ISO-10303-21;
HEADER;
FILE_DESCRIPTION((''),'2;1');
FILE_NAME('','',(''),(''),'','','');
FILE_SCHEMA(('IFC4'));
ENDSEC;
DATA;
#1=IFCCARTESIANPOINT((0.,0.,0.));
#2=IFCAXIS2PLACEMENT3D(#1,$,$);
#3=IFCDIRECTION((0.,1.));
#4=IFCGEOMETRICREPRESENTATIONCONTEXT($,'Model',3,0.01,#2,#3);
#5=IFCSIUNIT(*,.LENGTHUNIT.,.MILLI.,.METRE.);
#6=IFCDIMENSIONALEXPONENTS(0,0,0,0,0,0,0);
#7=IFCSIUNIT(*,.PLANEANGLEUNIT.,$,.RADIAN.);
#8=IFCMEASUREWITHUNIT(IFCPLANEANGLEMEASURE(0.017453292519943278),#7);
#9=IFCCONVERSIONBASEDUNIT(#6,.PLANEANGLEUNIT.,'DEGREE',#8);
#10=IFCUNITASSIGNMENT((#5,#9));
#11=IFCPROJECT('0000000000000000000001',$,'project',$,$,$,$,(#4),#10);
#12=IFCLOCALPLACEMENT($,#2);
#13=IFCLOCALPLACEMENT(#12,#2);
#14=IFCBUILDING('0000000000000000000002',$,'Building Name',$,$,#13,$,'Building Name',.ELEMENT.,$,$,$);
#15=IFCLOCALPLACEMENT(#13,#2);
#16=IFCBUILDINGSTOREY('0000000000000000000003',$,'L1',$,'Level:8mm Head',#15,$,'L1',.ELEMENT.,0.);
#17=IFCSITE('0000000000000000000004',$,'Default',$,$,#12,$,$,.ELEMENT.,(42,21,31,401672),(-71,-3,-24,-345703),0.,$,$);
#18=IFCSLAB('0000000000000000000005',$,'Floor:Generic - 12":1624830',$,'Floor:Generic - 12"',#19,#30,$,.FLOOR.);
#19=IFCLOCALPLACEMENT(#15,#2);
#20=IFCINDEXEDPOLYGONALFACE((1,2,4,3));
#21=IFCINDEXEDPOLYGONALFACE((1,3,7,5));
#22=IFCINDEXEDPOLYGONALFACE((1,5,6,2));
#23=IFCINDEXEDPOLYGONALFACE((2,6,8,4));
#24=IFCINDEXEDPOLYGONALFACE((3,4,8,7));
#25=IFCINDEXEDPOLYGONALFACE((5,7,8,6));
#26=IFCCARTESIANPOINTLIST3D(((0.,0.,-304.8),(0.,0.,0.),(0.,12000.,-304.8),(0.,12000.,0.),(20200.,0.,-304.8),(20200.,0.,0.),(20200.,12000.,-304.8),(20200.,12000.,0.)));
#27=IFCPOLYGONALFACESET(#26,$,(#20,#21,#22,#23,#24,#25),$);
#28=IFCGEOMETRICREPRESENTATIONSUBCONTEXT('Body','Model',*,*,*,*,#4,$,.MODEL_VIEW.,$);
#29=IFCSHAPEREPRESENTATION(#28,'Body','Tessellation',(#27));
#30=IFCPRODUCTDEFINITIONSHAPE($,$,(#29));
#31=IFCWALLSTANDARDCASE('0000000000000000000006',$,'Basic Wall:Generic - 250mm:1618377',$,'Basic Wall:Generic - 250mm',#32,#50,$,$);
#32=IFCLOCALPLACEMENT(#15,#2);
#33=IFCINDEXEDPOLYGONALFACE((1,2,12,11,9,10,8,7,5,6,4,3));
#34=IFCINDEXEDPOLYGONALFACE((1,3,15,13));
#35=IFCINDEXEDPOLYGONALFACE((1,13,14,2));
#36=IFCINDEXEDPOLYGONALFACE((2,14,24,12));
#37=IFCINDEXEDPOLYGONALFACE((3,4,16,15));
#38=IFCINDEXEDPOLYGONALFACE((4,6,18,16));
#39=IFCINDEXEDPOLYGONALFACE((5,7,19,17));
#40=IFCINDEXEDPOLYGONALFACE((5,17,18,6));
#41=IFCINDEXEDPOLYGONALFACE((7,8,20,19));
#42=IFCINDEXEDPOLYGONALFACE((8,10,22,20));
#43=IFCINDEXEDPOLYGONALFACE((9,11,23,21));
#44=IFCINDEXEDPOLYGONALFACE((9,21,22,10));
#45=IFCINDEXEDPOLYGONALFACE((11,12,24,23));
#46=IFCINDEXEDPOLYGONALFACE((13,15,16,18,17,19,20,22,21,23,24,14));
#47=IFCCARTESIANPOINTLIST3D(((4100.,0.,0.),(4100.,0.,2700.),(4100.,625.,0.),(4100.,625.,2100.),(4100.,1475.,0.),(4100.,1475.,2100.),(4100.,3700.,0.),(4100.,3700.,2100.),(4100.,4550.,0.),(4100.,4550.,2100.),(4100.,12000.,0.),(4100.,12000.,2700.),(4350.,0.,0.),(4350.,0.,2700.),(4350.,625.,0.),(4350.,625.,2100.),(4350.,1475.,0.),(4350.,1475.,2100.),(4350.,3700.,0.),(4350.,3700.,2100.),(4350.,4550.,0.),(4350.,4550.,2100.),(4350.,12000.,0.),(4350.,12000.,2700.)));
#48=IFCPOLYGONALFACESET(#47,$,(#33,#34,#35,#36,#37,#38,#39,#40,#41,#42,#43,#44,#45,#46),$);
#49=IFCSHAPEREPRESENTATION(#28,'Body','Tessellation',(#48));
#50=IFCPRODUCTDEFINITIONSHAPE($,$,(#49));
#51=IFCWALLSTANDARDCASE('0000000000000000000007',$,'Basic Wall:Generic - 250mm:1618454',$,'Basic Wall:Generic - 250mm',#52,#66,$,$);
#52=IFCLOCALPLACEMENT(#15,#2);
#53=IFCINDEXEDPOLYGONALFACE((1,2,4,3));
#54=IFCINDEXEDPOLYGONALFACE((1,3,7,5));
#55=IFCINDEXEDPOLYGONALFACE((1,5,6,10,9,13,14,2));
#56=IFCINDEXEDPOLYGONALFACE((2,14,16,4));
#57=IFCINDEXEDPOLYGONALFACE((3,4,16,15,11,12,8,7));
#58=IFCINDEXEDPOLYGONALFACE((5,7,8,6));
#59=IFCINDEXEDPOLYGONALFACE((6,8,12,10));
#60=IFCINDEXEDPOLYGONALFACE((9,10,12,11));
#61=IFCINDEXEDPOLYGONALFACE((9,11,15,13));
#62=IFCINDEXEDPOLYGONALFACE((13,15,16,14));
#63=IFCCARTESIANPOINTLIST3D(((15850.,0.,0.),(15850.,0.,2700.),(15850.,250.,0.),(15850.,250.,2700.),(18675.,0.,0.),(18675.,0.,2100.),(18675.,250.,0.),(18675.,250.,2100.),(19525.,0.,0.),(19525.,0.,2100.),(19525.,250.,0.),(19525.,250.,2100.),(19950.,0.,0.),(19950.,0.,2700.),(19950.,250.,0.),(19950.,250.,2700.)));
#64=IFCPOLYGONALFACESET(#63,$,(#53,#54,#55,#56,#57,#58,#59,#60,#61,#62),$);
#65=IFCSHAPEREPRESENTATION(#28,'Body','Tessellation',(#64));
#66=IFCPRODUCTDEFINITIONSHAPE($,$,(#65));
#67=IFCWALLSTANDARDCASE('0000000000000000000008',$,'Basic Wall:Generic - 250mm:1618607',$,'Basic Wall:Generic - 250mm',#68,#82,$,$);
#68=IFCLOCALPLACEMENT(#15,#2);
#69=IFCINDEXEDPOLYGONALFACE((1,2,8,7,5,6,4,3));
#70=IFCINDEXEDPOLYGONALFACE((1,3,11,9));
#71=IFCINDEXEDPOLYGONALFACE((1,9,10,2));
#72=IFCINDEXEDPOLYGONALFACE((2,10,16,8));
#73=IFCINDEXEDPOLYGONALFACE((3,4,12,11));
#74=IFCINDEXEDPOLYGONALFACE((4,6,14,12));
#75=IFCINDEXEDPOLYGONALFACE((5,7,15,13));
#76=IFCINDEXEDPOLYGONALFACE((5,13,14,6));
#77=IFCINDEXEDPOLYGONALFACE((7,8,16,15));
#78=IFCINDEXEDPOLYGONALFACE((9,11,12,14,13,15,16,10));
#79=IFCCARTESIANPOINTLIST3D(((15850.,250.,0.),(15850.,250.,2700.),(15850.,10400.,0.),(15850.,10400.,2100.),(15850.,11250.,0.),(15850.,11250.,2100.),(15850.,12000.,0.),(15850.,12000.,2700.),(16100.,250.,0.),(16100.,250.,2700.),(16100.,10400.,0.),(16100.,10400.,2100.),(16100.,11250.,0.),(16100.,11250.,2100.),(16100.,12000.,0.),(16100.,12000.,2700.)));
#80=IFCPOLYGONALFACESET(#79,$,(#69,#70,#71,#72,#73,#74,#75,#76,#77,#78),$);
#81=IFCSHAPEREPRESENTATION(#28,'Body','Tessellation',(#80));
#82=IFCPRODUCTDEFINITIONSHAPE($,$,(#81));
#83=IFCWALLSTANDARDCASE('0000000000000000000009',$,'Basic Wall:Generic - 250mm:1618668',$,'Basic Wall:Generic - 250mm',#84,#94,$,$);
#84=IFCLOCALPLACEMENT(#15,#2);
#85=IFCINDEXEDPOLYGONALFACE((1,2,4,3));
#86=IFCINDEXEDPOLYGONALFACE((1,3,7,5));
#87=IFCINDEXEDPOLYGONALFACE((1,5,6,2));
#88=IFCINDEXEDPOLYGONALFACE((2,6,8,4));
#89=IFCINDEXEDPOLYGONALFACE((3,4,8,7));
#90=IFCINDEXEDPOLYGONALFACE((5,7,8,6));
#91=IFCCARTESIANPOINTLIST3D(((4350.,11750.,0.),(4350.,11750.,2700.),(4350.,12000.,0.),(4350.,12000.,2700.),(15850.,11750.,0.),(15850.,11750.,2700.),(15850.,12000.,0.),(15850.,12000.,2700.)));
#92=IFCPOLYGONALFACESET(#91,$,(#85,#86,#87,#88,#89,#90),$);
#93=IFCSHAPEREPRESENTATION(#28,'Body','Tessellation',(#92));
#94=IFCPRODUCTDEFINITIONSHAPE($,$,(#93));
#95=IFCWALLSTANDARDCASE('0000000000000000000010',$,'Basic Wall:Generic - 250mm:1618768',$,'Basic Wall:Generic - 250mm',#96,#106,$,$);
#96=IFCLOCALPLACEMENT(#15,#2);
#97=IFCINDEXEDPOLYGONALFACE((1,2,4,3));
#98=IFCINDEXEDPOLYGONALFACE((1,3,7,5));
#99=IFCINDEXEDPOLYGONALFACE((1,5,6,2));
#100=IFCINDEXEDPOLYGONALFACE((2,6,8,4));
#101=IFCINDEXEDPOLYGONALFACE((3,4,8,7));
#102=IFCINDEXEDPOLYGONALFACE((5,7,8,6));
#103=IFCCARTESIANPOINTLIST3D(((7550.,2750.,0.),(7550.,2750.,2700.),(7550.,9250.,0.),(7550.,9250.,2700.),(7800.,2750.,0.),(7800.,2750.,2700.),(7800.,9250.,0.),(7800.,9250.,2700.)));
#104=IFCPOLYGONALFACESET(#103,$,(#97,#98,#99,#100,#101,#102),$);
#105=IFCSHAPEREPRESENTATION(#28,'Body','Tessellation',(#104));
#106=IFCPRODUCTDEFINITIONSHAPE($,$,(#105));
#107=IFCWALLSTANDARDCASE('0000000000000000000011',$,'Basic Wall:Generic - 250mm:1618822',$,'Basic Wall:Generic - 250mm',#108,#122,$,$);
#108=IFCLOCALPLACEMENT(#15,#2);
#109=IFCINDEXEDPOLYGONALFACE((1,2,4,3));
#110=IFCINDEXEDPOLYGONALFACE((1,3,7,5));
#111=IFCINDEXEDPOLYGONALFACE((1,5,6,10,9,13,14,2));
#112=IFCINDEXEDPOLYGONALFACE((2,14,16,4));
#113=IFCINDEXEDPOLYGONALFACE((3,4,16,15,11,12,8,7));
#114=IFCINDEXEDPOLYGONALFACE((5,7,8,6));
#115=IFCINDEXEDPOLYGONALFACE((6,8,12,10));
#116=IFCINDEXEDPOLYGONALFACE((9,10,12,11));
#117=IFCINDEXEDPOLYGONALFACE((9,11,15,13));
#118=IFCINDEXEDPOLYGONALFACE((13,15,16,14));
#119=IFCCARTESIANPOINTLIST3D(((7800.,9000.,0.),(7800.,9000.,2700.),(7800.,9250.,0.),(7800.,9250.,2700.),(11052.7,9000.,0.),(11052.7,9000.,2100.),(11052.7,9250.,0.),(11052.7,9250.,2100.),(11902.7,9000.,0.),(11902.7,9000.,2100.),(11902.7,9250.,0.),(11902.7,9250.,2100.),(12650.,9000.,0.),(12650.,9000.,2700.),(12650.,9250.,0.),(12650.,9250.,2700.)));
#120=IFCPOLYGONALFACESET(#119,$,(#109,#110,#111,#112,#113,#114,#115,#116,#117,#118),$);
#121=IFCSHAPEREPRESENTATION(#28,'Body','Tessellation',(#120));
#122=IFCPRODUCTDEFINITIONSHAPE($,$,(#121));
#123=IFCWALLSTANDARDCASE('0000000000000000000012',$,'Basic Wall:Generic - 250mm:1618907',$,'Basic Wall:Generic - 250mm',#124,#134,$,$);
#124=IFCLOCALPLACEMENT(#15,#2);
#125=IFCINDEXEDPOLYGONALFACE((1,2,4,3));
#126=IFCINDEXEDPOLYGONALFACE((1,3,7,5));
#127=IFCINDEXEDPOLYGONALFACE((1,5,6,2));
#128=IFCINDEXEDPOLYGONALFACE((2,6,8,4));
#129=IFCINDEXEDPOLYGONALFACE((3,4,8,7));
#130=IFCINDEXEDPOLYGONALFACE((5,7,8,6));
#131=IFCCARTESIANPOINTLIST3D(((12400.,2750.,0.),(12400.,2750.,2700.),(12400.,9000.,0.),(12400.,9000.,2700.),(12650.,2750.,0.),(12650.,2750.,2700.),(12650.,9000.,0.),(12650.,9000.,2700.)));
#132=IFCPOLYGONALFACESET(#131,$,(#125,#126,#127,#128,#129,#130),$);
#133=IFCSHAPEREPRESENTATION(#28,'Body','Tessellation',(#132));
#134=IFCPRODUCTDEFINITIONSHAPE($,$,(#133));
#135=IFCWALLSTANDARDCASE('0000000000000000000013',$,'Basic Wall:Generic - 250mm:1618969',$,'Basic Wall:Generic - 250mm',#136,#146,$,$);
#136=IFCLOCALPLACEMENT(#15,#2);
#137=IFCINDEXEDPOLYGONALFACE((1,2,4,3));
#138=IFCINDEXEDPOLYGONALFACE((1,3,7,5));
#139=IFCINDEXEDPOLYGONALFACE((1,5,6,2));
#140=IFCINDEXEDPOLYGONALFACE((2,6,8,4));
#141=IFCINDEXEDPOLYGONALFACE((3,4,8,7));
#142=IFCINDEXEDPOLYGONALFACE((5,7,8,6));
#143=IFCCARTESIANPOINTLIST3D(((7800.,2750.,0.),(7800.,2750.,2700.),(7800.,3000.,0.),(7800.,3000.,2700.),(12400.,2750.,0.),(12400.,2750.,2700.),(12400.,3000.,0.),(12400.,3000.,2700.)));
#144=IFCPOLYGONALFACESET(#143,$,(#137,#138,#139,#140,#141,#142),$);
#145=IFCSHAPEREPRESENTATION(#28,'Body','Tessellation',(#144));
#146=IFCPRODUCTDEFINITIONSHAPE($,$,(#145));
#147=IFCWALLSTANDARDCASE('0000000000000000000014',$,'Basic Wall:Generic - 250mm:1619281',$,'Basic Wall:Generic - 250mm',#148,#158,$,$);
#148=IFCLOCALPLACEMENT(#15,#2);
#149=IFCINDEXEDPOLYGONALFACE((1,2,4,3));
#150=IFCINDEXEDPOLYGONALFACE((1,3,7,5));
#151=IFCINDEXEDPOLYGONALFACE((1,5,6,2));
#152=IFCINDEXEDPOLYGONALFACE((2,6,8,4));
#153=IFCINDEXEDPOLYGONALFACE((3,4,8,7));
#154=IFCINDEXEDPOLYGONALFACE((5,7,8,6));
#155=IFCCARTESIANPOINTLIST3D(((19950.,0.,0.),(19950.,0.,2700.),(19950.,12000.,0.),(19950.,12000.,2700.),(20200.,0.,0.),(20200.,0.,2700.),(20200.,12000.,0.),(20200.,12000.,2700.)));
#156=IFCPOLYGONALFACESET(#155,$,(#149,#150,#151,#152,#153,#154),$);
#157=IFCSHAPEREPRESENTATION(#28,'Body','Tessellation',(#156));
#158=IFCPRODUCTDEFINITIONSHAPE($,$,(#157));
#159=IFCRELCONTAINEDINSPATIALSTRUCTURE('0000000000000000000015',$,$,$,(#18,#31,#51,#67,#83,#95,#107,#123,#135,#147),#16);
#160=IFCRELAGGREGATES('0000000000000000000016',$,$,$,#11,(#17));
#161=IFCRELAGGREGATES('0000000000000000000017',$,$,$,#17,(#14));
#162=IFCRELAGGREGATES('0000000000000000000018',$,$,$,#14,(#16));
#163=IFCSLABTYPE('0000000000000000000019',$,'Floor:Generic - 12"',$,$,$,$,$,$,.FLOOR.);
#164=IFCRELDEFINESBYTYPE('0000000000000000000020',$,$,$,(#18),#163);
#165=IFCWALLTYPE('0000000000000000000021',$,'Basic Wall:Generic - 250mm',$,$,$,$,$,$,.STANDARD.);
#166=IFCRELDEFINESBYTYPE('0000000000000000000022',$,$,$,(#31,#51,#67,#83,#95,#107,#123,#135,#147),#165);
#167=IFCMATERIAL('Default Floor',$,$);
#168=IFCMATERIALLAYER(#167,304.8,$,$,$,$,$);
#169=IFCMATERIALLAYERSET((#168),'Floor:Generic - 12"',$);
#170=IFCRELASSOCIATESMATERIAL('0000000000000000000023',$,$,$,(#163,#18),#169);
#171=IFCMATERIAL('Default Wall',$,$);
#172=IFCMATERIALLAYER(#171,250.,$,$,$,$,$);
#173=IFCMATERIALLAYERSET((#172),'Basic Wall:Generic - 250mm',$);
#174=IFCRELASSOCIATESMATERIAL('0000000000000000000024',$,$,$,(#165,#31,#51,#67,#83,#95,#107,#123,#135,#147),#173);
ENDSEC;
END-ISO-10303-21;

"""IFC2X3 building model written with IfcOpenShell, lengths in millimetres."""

from ifc_helpers import new_model, entity, si_unit, converted_unit, direction, frame, frame_2d, origin, origin_2d_with_axis, place, context, subcontext, project, spatial, rectangle, extrude, material, layer, layer_set, layer_usage, type_object, element, save


model = new_model("IFC2X3")

# Units and contexts
model_context = context("Model", 3, precision=0.01, world=origin(), true_north=direction((0.0, 1.0)))
body_context = subcontext(model_context, "Body", "Model", "MODEL_VIEW")
ifc_project = project(units=[si_unit("LENGTHUNIT", "METRE", prefix="MILLI"), converted_unit("PLANEANGLEUNIT", "DEGREE", entity("IfcPlaneAngleMeasure", 0.017453292519943278), si_unit("PLANEANGLEUNIT", "RADIAN"), dimensions=[0, 0, 0, 0, 0, 0, 0])], contexts=[model_context])

# Site, building, storey
site_placement = place(None, origin())
site = spatial("IfcSite", under=ifc_project, at=site_placement, Name="Default", CompositionType="ELEMENT", RefLatitude=(42, 21, 31, 401672), RefLongitude=(-71, -3, -24, -345703), RefElevation=0.0)
building_placement = place(site_placement, origin())
building = spatial("IfcBuilding", under=site, at=building_placement, Name="Building Name", LongName="Building Name", CompositionType="ELEMENT")
storey_placement = place(building_placement, origin())
storey = spatial("IfcBuildingStorey", under=building, at=storey_placement, Name="L1", ObjectType="Level:8mm Head", LongName="L1", CompositionType="ELEMENT", Elevation=0.0)

# Slab
ifc_material_1 = material(Name="Default Floor")
ifc_layer_1 = layer(ifc_material_1, 304.8)
ifc_layer_set_1 = layer_set([ifc_layer_1], Name="Floor:Generic - 12\"")
ifc_layer_usage_1 = layer_usage(ifc_layer_set_1, "AXIS3", "POSITIVE", 0.0)
slab_type = type_object("IfcSlabType", Name="Floor:Generic - 12\"", PredefinedType="FLOOR", material=ifc_layer_set_1)
slab_placement = place(storey_placement, origin())
element("IfcSlab", 1, at=slab_placement, inside=storey, type_object=slab_type, material=ifc_layer_usage_1, Name="Floor:Generic - 12\":1624830", ObjectType="Floor:Generic - 12\"", PredefinedType="FLOOR", context=body_context, shape_type="SweptSolid", body=[
    extrude(rectangle(XDim=12000.0, YDim=20200.0, at=origin_2d_with_axis()), frame((10100.0, 6000.0, 0.0), z_axis=(0.0, 0.0, -1.0), x_axis=(0.0, 1.0, 0.0)), (0.0, 0.0, 1.0), 304.8),
])

# Wall, openings
ifc_material_2 = material(Name="Default Wall")
ifc_layer_2 = layer(ifc_material_2, 250.0)
ifc_layer_set_2 = layer_set([ifc_layer_2], Name="Basic Wall:Generic - 250mm")
ifc_layer_usage_2 = layer_usage(ifc_layer_set_2, "AXIS2", "NEGATIVE", 125.0)
wall_type = type_object("IfcWallType", Name="Basic Wall:Generic - 250mm", PredefinedType="STANDARD", material=ifc_layer_set_2)
wall_1_placement = place(storey_placement, frame((4225.0, 12000.0, 0.0), z_axis=(0.0, 0.0, 1.0), x_axis=(0.0, -1.0, 0.0)))
wall_1 = element("IfcWallStandardCase", 2, at=wall_1_placement, inside=storey, type_object=wall_type, material=ifc_layer_usage_2, Name="Basic Wall:Generic - 250mm:1618377", ObjectType="Basic Wall:Generic - 250mm", context=body_context, shape_type="SweptSolid", body=[
    extrude(rectangle(XDim=12000.0, YDim=250.0, at=frame_2d((6000.0, 0.0), x_axis=(1.0, 0.0))), origin(), (0.0, 0.0, 1.0), 2700.0),
])
opening_1_placement = place(wall_1_placement, frame((10525.0, -125.0, 0.0)))
element("IfcOpeningElement", 3, at=opening_1_placement, cuts=wall_1, ObjectType="Opening", context=body_context, shape_type="SweptSolid", body=[
    extrude(rectangle(XDim=2100.0, YDim=850.0, at=frame_2d((1050.0, 425.0), x_axis=(1.0, 0.0))), frame((0.0, 0.0, 0.0), z_axis=(0.0, 1.0, 0.0), x_axis=(0.0, 0.0, 1.0)), (0.0, 0.0, 1.0), 250.0),
])
opening_2_placement = place(wall_1_placement, frame((7450.0, -125.0, 0.0)))
element("IfcOpeningElement", 4, at=opening_2_placement, cuts=wall_1, ObjectType="Opening", context=body_context, shape_type="SweptSolid", body=[
    extrude(rectangle(XDim=2100.0, YDim=850.0, at=frame_2d((1050.0, 425.0), x_axis=(1.0, 0.0))), frame((0.0, 0.0, 0.0), z_axis=(0.0, 1.0, 0.0), x_axis=(0.0, 0.0, 1.0)), (0.0, 0.0, 1.0), 250.0),
])

# Walls, openings
ifc_layer_usage_3 = layer_usage(ifc_layer_set_2, "AXIS2", "NEGATIVE", 125.0)
wall_2_placement = place(storey_placement, frame((15850.0, 125.0, 0.0)))
wall_2 = element("IfcWallStandardCase", 5, at=wall_2_placement, inside=storey, type_object=wall_type, material=ifc_layer_usage_3, Name="Basic Wall:Generic - 250mm:1618454", ObjectType="Basic Wall:Generic - 250mm", context=body_context, shape_type="SweptSolid", body=[
    extrude(rectangle(XDim=4100.0, YDim=250.0, at=frame_2d((2050.0, 0.0), x_axis=(1.0, 0.0))), origin(), (0.0, 0.0, 1.0), 2700.0),
])
opening_3_placement = place(wall_2_placement, frame((2825.0, -125.0, 0.0)))
element("IfcOpeningElement", 6, at=opening_3_placement, cuts=wall_2, ObjectType="Opening", context=body_context, shape_type="SweptSolid", body=[
    extrude(rectangle(XDim=2100.0, YDim=850.0, at=frame_2d((1050.0, 425.0), x_axis=(1.0, 0.0))), frame((0.0, 0.0, 0.0), z_axis=(0.0, 1.0, 0.0), x_axis=(0.0, 0.0, 1.0)), (0.0, 0.0, 1.0), 250.0),
])
ifc_layer_usage_4 = layer_usage(ifc_layer_set_2, "AXIS2", "NEGATIVE", 125.0)
wall_3_placement = place(storey_placement, frame((15975.0, 250.0, 0.0), z_axis=(0.0, 0.0, 1.0), x_axis=(0.0, 1.0, 0.0)))
wall_3 = element("IfcWallStandardCase", 7, at=wall_3_placement, inside=storey, type_object=wall_type, material=ifc_layer_usage_4, Name="Basic Wall:Generic - 250mm:1618607", ObjectType="Basic Wall:Generic - 250mm", context=body_context, shape_type="SweptSolid", body=[
    extrude(rectangle(XDim=11750.0, YDim=250.0, at=frame_2d((5875.0, 0.0), x_axis=(-1.0, 0.0))), origin(), (0.0, 0.0, 1.0), 2700.0),
])
opening_4_placement = place(wall_3_placement, frame((10150.0, -125.0, 0.0)))
element("IfcOpeningElement", 8, at=opening_4_placement, cuts=wall_3, ObjectType="Opening", context=body_context, shape_type="SweptSolid", body=[
    extrude(rectangle(XDim=2100.0, YDim=850.0, at=frame_2d((1050.0, 425.0), x_axis=(1.0, 0.0))), frame((0.0, 0.0, 0.0), z_axis=(0.0, 1.0, 0.0), x_axis=(0.0, 0.0, 1.0)), (0.0, 0.0, 1.0), 250.0),
])

# Walls
ifc_layer_usage_5 = layer_usage(ifc_layer_set_2, "AXIS2", "NEGATIVE", 125.0)
wall_4_placement = place(storey_placement, frame((15850.0, 11875.0, 0.0), z_axis=(0.0, 0.0, 1.0), x_axis=(-1.0, 0.0, 0.0)))
element("IfcWallStandardCase", 9, at=wall_4_placement, inside=storey, type_object=wall_type, material=ifc_layer_usage_5, Name="Basic Wall:Generic - 250mm:1618668", ObjectType="Basic Wall:Generic - 250mm", context=body_context, shape_type="SweptSolid", body=[
    extrude(rectangle(XDim=11500.0, YDim=250.0, at=frame_2d((5750.0, 0.0), x_axis=(-1.0, 0.0))), origin(), (0.0, 0.0, 1.0), 2700.0),
])
ifc_layer_usage_6 = layer_usage(ifc_layer_set_2, "AXIS2", "NEGATIVE", 125.0)
wall_5_placement = place(storey_placement, frame((7675.0, 2750.0, 0.0), z_axis=(0.0, 0.0, 1.0), x_axis=(0.0, 1.0, 0.0)))
element("IfcWallStandardCase", 10, at=wall_5_placement, inside=storey, type_object=wall_type, material=ifc_layer_usage_6, Name="Basic Wall:Generic - 250mm:1618768", ObjectType="Basic Wall:Generic - 250mm", context=body_context, shape_type="SweptSolid", body=[
    extrude(rectangle(XDim=6500.0, YDim=250.0, at=frame_2d((3250.0, 0.0), x_axis=(-1.0, 0.0))), origin(), (0.0, 0.0, 1.0), 2700.0),
])

# Wall, opening
ifc_layer_usage_7 = layer_usage(ifc_layer_set_2, "AXIS2", "NEGATIVE", 125.0)
wall_6_placement = place(storey_placement, frame((7800.0, 9125.0, 0.0)))
wall_6 = element("IfcWallStandardCase", 11, at=wall_6_placement, inside=storey, type_object=wall_type, material=ifc_layer_usage_7, Name="Basic Wall:Generic - 250mm:1618822", ObjectType="Basic Wall:Generic - 250mm", context=body_context, shape_type="SweptSolid", body=[
    extrude(rectangle(XDim=4850.0, YDim=250.0, at=frame_2d((2425.0, 0.0), x_axis=(-1.0, 0.0))), origin(), (0.0, 0.0, 1.0), 2700.0),
])
opening_5_placement = place(wall_6_placement, frame((4102.7, 125.0, 0.0)))
element("IfcOpeningElement", 12, at=opening_5_placement, cuts=wall_6, ObjectType="Opening", context=body_context, shape_type="SweptSolid", body=[
    extrude(rectangle(XDim=2100.0, YDim=850.0, at=frame_2d((1050.0, 425.0), x_axis=(1.0, 0.0))), frame((0.0, 0.0, 0.0), z_axis=(0.0, -1.0, 0.0), x_axis=(0.0, 0.0, 1.0)), (0.0, 0.0, 1.0), 250.0),
])

# Walls
ifc_layer_usage_8 = layer_usage(ifc_layer_set_2, "AXIS2", "NEGATIVE", 125.0)
wall_7_placement = place(storey_placement, frame((12525.0, 9000.0, 0.0), z_axis=(0.0, 0.0, 1.0), x_axis=(0.0, -1.0, 0.0)))
element("IfcWallStandardCase", 13, at=wall_7_placement, inside=storey, type_object=wall_type, material=ifc_layer_usage_8, Name="Basic Wall:Generic - 250mm:1618907", ObjectType="Basic Wall:Generic - 250mm", context=body_context, shape_type="SweptSolid", body=[
    extrude(rectangle(XDim=6250.0, YDim=250.0, at=frame_2d((3125.0, 0.0), x_axis=(-1.0, 0.0))), origin(), (0.0, 0.0, 1.0), 2700.0),
])
ifc_layer_usage_9 = layer_usage(ifc_layer_set_2, "AXIS2", "NEGATIVE", 125.0)
wall_8_placement = place(storey_placement, frame((12400.0, 2875.0, 0.0), z_axis=(0.0, 0.0, 1.0), x_axis=(-1.0, 0.0, 0.0)))
element("IfcWallStandardCase", 14, at=wall_8_placement, inside=storey, type_object=wall_type, material=ifc_layer_usage_9, Name="Basic Wall:Generic - 250mm:1618969", ObjectType="Basic Wall:Generic - 250mm", context=body_context, shape_type="SweptSolid", body=[
    extrude(rectangle(XDim=4600.0, YDim=250.0, at=frame_2d((2300.0, 0.0), x_axis=(-1.0, 0.0))), origin(), (0.0, 0.0, 1.0), 2700.0),
])
ifc_layer_usage_10 = layer_usage(ifc_layer_set_2, "AXIS2", "NEGATIVE", 125.0)
wall_9_placement = place(storey_placement, frame((20075.0, 0.0, 0.0), z_axis=(0.0, 0.0, 1.0), x_axis=(0.0, 1.0, 0.0)))
element("IfcWallStandardCase", 15, at=wall_9_placement, inside=storey, type_object=wall_type, material=ifc_layer_usage_10, Name="Basic Wall:Generic - 250mm:1619281", ObjectType="Basic Wall:Generic - 250mm", context=body_context, shape_type="SweptSolid", body=[
    extrude(rectangle(XDim=12000.0, YDim=250.0, at=frame_2d((6000.0, 0.0), x_axis=(-1.0, 0.0))), origin(), (0.0, 0.0, 1.0), 2700.0),
])

save(model, "model.ifc")
